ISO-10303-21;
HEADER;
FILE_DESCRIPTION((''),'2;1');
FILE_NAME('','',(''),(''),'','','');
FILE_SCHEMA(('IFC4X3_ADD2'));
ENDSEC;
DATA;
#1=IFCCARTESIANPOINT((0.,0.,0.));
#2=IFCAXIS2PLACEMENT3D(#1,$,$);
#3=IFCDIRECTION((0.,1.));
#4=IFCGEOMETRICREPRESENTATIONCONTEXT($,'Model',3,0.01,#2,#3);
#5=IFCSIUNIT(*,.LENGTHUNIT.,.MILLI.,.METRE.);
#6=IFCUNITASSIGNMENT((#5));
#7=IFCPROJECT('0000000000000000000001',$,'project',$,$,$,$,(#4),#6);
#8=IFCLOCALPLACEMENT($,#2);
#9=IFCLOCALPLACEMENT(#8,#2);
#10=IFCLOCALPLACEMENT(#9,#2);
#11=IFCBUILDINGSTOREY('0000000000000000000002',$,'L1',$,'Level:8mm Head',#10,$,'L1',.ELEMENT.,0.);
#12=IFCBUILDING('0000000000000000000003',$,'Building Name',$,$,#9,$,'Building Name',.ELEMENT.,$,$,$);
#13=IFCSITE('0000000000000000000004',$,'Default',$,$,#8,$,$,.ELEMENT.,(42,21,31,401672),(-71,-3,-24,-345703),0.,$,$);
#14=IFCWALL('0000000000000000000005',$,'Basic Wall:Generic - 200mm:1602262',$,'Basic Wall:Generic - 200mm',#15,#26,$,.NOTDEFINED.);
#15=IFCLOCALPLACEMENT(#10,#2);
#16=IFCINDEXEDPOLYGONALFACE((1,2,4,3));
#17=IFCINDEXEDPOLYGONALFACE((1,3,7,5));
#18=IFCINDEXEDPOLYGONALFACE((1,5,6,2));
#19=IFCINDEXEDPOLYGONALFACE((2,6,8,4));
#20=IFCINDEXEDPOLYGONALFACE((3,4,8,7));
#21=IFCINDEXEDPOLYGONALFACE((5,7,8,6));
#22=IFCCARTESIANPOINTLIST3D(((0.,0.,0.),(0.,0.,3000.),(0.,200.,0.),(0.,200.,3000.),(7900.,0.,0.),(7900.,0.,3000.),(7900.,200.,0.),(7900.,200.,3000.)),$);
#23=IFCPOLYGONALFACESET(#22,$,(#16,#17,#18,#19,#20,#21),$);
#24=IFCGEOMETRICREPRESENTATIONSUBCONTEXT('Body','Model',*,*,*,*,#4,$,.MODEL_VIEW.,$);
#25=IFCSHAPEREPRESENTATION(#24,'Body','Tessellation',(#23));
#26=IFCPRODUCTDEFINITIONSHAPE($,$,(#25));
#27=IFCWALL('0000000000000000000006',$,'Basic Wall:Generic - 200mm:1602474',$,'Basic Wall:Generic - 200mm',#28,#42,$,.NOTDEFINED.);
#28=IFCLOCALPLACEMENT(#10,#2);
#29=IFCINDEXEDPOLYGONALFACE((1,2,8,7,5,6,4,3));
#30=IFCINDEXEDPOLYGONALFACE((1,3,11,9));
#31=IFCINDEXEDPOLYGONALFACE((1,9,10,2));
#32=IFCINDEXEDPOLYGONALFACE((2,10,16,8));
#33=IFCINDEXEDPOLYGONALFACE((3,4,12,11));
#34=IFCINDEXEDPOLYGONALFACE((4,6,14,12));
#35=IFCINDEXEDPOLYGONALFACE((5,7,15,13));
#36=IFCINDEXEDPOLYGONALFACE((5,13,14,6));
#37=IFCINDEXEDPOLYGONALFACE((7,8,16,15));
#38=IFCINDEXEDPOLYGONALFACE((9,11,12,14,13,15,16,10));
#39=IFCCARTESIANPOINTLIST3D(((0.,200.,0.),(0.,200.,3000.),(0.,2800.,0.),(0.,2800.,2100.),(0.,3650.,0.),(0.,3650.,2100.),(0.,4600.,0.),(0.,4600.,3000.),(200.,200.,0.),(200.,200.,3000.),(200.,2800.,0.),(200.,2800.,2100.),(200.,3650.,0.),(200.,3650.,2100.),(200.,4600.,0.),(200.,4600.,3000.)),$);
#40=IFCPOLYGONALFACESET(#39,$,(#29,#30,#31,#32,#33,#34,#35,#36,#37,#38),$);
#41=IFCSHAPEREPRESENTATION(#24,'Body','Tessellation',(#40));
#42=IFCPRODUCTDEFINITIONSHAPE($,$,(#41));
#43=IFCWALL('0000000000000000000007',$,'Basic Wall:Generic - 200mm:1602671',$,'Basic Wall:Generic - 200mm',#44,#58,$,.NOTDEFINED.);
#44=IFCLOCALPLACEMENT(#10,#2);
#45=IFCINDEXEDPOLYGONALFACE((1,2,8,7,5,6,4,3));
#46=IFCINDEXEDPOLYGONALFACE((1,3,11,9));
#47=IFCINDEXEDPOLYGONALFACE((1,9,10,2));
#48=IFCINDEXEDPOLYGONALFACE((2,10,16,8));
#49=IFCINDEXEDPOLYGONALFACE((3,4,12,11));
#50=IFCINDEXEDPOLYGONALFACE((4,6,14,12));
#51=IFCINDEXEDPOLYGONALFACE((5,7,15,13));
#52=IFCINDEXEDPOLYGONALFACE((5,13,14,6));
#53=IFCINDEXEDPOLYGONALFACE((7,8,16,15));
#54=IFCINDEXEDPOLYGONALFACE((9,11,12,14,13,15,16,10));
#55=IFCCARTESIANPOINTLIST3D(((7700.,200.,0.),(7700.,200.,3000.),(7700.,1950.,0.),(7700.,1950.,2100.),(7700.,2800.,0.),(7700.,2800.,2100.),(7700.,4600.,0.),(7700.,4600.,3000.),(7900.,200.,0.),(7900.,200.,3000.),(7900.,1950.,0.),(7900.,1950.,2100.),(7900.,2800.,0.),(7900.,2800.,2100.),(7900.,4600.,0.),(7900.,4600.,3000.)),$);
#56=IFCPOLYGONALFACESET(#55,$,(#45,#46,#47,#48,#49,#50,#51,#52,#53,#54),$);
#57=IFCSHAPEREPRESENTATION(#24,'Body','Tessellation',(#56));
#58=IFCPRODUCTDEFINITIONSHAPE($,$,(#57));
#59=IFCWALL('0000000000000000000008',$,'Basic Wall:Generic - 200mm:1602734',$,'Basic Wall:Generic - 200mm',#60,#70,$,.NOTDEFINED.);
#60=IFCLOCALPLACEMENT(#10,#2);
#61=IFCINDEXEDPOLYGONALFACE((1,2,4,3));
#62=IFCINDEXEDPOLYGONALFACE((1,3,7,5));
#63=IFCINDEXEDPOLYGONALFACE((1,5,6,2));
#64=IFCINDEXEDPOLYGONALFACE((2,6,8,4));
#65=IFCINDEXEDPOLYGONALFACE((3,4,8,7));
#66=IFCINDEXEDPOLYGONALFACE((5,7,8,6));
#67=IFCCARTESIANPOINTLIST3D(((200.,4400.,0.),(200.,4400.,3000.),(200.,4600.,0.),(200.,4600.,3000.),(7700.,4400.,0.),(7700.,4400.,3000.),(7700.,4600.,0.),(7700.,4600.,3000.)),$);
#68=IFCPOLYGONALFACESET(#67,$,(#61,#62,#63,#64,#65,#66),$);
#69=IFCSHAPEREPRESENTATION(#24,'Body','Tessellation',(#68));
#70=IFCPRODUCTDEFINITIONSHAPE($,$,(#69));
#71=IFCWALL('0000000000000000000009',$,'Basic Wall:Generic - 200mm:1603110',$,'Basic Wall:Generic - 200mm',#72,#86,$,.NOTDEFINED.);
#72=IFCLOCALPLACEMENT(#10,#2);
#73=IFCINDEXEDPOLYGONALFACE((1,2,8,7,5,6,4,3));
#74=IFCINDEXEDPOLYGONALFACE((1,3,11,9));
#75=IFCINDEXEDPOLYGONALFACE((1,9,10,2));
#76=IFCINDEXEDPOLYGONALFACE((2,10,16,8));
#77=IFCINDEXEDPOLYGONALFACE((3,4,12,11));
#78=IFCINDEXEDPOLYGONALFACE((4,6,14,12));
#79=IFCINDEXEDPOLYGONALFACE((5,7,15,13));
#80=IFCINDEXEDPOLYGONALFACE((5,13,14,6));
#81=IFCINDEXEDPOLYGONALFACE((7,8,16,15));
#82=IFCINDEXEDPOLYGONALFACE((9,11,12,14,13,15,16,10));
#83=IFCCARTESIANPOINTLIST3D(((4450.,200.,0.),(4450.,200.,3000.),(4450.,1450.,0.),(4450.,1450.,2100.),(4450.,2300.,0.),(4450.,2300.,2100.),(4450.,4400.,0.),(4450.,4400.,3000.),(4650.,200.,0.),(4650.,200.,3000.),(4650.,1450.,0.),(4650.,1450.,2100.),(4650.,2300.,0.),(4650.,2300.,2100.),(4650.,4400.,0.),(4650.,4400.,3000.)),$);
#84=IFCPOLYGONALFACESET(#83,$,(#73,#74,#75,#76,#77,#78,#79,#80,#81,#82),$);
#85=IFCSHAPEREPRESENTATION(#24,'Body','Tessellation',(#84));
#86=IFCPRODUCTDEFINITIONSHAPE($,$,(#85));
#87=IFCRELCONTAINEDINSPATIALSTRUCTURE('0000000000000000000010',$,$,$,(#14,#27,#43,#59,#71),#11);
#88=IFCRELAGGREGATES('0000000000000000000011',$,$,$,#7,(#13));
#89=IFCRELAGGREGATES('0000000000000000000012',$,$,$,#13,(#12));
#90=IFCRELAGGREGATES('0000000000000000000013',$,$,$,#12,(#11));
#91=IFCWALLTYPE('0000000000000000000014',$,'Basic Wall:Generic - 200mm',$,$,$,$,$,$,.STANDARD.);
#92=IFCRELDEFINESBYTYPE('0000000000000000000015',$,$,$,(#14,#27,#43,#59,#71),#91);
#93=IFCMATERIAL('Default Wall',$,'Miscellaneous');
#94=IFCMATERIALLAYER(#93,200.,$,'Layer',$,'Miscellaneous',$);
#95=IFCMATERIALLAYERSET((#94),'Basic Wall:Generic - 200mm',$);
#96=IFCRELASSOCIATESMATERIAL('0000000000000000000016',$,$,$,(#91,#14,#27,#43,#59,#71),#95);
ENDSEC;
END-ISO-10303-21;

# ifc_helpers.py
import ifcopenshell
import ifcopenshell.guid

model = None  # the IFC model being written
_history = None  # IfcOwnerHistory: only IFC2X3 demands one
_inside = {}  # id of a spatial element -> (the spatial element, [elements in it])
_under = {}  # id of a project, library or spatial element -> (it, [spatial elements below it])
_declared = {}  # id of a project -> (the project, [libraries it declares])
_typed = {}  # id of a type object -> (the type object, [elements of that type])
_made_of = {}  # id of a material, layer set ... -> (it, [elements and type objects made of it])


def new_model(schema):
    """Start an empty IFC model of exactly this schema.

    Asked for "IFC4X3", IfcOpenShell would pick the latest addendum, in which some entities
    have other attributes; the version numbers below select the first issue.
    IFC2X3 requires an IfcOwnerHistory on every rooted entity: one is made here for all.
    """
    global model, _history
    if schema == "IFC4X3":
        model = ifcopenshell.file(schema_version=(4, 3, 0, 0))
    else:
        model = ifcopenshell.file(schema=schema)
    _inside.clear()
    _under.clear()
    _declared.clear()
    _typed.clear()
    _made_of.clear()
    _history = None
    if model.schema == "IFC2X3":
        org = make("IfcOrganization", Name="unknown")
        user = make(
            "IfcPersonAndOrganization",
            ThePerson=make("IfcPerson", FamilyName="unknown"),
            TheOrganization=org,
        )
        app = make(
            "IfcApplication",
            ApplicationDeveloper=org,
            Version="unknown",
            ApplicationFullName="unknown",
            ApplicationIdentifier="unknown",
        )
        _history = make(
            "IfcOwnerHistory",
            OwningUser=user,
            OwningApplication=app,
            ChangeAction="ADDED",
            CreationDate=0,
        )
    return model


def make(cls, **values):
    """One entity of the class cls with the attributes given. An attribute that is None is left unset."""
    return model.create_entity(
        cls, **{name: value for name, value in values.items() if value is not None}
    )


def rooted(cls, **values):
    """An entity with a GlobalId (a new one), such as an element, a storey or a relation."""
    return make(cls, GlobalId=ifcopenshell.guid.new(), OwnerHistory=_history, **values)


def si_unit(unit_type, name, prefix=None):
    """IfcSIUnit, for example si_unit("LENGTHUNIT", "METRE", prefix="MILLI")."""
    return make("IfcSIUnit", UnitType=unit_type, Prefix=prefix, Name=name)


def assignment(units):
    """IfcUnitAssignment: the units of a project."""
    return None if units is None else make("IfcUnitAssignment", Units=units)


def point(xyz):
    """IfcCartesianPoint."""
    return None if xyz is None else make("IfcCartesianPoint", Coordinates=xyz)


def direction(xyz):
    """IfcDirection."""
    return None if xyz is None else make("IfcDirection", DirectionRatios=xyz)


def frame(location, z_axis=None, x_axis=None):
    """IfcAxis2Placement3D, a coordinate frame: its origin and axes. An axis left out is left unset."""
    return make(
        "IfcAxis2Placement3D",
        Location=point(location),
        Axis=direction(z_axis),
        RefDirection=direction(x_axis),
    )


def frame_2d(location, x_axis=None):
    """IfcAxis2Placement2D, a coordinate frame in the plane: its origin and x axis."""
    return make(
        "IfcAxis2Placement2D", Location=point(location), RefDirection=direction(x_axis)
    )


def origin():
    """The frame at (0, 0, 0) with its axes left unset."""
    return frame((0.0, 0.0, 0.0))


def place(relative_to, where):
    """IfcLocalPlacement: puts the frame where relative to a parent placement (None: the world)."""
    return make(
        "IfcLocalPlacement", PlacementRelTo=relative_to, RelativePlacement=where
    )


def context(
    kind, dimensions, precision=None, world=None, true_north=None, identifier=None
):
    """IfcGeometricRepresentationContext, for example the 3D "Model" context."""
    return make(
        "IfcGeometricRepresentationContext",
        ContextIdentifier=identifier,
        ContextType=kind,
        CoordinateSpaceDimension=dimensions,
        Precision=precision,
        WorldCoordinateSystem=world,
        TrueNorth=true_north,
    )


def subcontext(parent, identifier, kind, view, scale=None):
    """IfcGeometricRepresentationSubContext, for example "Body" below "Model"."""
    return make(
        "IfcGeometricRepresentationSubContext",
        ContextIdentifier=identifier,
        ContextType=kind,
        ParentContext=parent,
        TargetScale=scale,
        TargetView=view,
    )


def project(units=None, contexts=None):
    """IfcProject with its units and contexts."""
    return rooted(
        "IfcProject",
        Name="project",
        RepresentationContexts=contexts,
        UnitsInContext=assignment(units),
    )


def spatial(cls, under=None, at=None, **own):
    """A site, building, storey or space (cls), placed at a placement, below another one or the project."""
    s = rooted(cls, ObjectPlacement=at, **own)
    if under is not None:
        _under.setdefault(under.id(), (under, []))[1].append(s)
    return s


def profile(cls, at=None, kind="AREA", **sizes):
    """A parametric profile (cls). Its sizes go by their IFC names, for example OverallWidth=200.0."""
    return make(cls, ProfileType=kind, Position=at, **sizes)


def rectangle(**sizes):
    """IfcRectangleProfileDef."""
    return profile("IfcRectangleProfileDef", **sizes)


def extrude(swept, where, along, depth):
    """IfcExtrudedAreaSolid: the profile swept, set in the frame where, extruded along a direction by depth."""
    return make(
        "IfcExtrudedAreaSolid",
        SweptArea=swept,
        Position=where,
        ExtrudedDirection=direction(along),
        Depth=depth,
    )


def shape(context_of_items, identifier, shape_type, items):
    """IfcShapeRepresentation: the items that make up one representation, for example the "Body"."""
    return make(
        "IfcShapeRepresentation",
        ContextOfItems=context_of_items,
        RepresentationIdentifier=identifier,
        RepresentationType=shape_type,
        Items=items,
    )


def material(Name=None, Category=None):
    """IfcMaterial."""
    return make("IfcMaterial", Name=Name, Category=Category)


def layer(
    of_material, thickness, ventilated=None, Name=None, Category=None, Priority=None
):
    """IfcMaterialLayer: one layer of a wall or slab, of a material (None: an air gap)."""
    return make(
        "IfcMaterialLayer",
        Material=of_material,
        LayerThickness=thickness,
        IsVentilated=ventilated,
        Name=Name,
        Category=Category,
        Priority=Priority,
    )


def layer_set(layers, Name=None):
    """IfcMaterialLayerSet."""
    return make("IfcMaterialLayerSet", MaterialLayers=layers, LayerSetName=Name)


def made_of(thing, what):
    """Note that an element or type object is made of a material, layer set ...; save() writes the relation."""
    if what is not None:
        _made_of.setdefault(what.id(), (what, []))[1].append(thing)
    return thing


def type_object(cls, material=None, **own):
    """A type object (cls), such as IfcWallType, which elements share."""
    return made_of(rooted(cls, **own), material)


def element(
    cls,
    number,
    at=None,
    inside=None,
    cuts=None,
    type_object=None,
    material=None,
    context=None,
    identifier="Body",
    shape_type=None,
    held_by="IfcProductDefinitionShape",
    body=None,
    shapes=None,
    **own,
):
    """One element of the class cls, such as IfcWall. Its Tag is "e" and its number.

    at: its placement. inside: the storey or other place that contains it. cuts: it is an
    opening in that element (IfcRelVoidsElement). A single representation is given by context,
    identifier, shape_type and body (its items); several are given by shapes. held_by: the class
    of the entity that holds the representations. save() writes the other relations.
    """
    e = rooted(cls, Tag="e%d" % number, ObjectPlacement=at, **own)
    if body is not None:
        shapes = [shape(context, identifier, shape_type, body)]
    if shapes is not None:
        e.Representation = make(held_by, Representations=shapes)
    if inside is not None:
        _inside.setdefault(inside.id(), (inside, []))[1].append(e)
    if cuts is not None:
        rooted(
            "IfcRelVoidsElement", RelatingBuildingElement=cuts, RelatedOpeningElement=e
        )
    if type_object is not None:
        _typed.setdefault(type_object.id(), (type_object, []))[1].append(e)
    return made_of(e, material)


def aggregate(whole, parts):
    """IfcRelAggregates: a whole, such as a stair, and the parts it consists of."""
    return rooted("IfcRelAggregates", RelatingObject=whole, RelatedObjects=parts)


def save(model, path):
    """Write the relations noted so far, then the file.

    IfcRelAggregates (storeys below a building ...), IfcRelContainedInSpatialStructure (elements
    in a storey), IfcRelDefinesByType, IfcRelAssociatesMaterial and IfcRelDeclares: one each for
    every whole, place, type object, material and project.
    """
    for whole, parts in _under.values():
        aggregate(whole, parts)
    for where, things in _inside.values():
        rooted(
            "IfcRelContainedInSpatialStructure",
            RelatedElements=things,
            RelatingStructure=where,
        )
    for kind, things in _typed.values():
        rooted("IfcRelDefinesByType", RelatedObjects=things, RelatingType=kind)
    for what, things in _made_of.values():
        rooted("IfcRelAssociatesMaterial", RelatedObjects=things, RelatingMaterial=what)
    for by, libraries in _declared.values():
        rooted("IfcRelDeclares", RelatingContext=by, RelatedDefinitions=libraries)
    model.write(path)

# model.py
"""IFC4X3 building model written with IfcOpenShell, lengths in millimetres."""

from ifc_helpers import new_model, si_unit, direction, frame, frame_2d, origin, place, context, subcontext, project, spatial, rectangle, extrude, material, layer, layer_set, type_object, element, save


model = new_model("IFC4X3")

# Units and contexts
model_context = context("Model", 3, precision=0.01, world=origin(), true_north=direction((0.0, 1.0)))
body_context = subcontext(model_context, "Body", "Model", "MODEL_VIEW")
ifc_project = project(units=[si_unit("LENGTHUNIT", "METRE", prefix="MILLI")], contexts=[model_context])

# Site, building, storey
site_placement = place(None, origin())
site = spatial("IfcSite", under=ifc_project, at=site_placement, Name="Default", CompositionType="ELEMENT", RefLatitude=(42, 21, 31, 401672), RefLongitude=(-71, -3, -24, -345703), RefElevation=0.0)
building_placement = place(site_placement, origin())
building = spatial("IfcBuilding", under=site, at=building_placement, Name="Building Name", LongName="Building Name", CompositionType="ELEMENT")
storey_placement = place(building_placement, origin())
storey = spatial("IfcBuildingStorey", under=building, at=storey_placement, Name="L1", ObjectType="Level:8mm Head", LongName="L1", CompositionType="ELEMENT", Elevation=0.0)

# Wall
ifc_material = material(Name="Default Wall", Category="Miscellaneous")
ifc_layer = layer(ifc_material, 200.0, Name="Layer", Category="Miscellaneous")
ifc_layer_set = layer_set([ifc_layer], Name="Basic Wall:Generic - 200mm")
wall_type = type_object("IfcWallType", Name="Basic Wall:Generic - 200mm", PredefinedType="STANDARD", material=ifc_layer_set)
wall_1_placement = place(storey_placement, frame((0.0, 100.0, 0.0)))
element("IfcWall", 1, at=wall_1_placement, inside=storey, type_object=wall_type, material=ifc_layer_set, Name="Basic Wall:Generic - 200mm:1602262", ObjectType="Basic Wall:Generic - 200mm", PredefinedType="NOTDEFINED", context=body_context, shape_type="SweptSolid", body=[
    extrude(rectangle(XDim=7900.0, YDim=200.0, at=frame_2d((3950.0, 0.0), x_axis=(-1.0, 0.0))), origin(), (0.0, 0.0, 1.0), 3000.0),
])

# Walls, openings
wall_2_placement = place(storey_placement, frame((100.0, 200.0, 0.0), z_axis=(0.0, 0.0, 1.0), x_axis=(0.0, 1.0, 0.0)))
wall_2 = element("IfcWall", 2, at=wall_2_placement, inside=storey, type_object=wall_type, material=ifc_layer_set, Name="Basic Wall:Generic - 200mm:1602474", ObjectType="Basic Wall:Generic - 200mm", PredefinedType="NOTDEFINED", context=body_context, shape_type="SweptSolid", body=[
    extrude(rectangle(XDim=4400.0, YDim=200.0, at=frame_2d((2200.0, 0.0), x_axis=(1.0, 0.0))), origin(), (0.0, 0.0, 1.0), 3000.0),
])
opening_1_placement = place(wall_2_placement, frame((2600.0, -100.0, 0.0)))
element("IfcOpeningElement", 3, at=opening_1_placement, cuts=wall_2, PredefinedType="OPENING", context=body_context, shape_type="SweptSolid", body=[
    extrude(rectangle(XDim=2100.0, YDim=850.0, at=frame_2d((1050.0, 425.0), x_axis=(1.0, 0.0))), frame((0.0, 0.0, 0.0), z_axis=(0.0, 1.0, 0.0), x_axis=(0.0, 0.0, 1.0)), (0.0, 0.0, 1.0), 200.0),
])
wall_3_placement = place(storey_placement, frame((7800.0, 200.0, 0.0), z_axis=(0.0, 0.0, 1.0), x_axis=(0.0, 1.0, 0.0)))
wall_3 = element("IfcWall", 4, at=wall_3_placement, inside=storey, type_object=wall_type, material=ifc_layer_set, Name="Basic Wall:Generic - 200mm:1602671", ObjectType="Basic Wall:Generic - 200mm", PredefinedType="NOTDEFINED", context=body_context, shape_type="SweptSolid", body=[
    extrude(rectangle(XDim=4400.0, YDim=200.0, at=frame_2d((2200.0, 0.0), x_axis=(-1.0, 0.0))), origin(), (0.0, 0.0, 1.0), 3000.0),
])
opening_2_placement = place(wall_3_placement, frame((1750.0, -100.0, 0.0)))
element("IfcOpeningElement", 5, at=opening_2_placement, cuts=wall_3, PredefinedType="OPENING", context=body_context, shape_type="SweptSolid", body=[
    extrude(rectangle(XDim=2100.0, YDim=850.0, at=frame_2d((1050.0, 425.0), x_axis=(1.0, 0.0))), frame((0.0, 0.0, 0.0), z_axis=(0.0, 1.0, 0.0), x_axis=(0.0, 0.0, 1.0)), (0.0, 0.0, 1.0), 200.0),
])

# Wall
wall_4_placement = place(storey_placement, frame((7700.0, 4500.0, 0.0), z_axis=(0.0, 0.0, 1.0), x_axis=(-1.0, 0.0, 0.0)))
element("IfcWall", 6, at=wall_4_placement, inside=storey, type_object=wall_type, material=ifc_layer_set, Name="Basic Wall:Generic - 200mm:1602734", ObjectType="Basic Wall:Generic - 200mm", PredefinedType="NOTDEFINED", context=body_context, shape_type="SweptSolid", body=[
    extrude(rectangle(XDim=7500.0, YDim=200.0, at=frame_2d((3750.0, 0.0), x_axis=(-1.0, 0.0))), origin(), (0.0, 0.0, 1.0), 3000.0),
])

# Wall, opening
wall_5_placement = place(storey_placement, frame((4550.0, 200.0, 0.0), z_axis=(0.0, 0.0, 1.0), x_axis=(0.0, 1.0, 0.0)))
wall_5 = element("IfcWall", 7, at=wall_5_placement, inside=storey, type_object=wall_type, material=ifc_layer_set, Name="Basic Wall:Generic - 200mm:1603110", ObjectType="Basic Wall:Generic - 200mm", PredefinedType="NOTDEFINED", context=body_context, shape_type="SweptSolid", body=[
    extrude(rectangle(XDim=4200.0, YDim=200.0, at=frame_2d((2100.0, 0.0), x_axis=(-1.0, 0.0))), origin(), (0.0, 0.0, 1.0), 3000.0),
])
opening_3_placement = place(wall_5_placement, frame((1250.0, -100.0, 0.0)))
element("IfcOpeningElement", 8, at=opening_3_placement, cuts=wall_5, PredefinedType="OPENING", context=body_context, shape_type="SweptSolid", body=[
    extrude(rectangle(XDim=2100.0, YDim=850.0, at=frame_2d((1050.0, 425.0), x_axis=(1.0, 0.0))), frame((0.0, 0.0, 0.0), z_axis=(0.0, 1.0, 0.0), x_axis=(0.0, 0.0, 1.0)), (0.0, 0.0, 1.0), 200.0),
])

save(model, "model.ifc")
